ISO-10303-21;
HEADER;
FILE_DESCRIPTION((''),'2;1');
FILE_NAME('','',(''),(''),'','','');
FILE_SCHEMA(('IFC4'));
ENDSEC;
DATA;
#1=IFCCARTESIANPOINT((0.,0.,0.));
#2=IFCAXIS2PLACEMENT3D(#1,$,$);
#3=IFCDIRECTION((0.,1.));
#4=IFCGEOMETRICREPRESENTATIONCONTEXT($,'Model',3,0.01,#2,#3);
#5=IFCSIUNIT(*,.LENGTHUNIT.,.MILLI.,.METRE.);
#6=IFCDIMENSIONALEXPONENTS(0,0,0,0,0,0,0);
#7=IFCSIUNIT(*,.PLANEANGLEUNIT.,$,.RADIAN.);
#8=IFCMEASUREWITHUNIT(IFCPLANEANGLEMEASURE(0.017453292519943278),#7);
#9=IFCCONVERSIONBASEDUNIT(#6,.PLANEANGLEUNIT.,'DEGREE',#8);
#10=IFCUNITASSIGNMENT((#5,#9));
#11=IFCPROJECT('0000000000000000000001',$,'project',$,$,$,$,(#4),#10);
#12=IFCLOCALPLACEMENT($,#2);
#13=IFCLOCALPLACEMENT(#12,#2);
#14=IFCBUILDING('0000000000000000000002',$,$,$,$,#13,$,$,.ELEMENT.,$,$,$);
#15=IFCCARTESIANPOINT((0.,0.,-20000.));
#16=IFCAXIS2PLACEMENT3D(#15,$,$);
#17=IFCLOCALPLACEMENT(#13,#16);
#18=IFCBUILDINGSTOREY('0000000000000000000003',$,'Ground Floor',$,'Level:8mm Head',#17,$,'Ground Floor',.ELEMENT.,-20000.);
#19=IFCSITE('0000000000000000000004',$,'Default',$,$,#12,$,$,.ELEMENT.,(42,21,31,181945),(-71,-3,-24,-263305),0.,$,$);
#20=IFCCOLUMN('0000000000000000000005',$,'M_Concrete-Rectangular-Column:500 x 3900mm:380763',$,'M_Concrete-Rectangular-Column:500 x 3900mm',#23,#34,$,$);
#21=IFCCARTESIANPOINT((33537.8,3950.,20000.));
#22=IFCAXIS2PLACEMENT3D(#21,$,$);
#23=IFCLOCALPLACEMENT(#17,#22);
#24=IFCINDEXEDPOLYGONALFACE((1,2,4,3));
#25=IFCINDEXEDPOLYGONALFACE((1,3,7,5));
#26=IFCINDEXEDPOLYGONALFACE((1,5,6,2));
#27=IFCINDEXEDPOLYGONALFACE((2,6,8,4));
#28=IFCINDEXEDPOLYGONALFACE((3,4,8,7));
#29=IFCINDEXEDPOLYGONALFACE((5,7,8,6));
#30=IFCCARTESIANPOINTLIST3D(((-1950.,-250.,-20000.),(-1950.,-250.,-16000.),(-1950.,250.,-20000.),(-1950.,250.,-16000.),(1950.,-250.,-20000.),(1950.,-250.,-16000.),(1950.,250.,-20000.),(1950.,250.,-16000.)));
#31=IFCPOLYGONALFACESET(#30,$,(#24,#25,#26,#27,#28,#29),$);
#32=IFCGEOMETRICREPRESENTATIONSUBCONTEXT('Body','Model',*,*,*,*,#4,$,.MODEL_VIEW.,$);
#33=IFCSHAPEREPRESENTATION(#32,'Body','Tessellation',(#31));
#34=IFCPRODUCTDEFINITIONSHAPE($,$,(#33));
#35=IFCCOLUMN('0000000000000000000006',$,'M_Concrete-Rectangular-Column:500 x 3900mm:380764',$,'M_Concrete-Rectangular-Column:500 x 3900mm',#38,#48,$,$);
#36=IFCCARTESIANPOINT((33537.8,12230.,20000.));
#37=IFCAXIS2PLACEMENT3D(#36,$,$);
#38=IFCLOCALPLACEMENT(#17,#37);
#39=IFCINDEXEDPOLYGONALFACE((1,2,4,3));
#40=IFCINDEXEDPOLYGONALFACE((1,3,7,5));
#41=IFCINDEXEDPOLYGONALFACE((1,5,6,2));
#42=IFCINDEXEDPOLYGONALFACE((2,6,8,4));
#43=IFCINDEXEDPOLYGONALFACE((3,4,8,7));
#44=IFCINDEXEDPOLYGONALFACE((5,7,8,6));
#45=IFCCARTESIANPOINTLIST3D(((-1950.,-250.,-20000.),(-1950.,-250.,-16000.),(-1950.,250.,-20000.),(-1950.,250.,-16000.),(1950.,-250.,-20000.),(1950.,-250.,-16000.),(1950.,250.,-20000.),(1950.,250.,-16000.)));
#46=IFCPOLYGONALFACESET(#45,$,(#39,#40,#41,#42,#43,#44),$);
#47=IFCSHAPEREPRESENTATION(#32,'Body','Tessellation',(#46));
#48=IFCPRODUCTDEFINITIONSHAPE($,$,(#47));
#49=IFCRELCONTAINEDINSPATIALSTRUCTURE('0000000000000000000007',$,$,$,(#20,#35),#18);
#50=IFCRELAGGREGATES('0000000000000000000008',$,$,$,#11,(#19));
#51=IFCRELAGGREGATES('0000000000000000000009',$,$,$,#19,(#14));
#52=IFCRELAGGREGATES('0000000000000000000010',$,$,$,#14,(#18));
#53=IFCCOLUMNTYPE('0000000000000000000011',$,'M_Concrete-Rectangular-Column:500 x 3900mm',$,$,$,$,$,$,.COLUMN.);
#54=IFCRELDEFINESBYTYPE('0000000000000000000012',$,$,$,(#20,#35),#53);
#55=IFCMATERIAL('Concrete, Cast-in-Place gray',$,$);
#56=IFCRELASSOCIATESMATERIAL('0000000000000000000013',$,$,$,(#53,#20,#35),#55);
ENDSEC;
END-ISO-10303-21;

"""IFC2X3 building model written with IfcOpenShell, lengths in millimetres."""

from ifc_helpers import new_model, entity, si_unit, converted_unit, direction, frame, origin, origin_2d_with_axis, place, context, subcontext, project, spatial, rectangle, extrude, source, transform, mapped, material, type_object, type_shapes, element, save


model = new_model("IFC2X3")

# Units and contexts
model_context = context("Model", 3, precision=0.01, world=origin(), true_north=direction((0.0, 1.0)))
body_context = subcontext(model_context, "Body", "Model", "MODEL_VIEW")
ifc_project = project(units=[si_unit("LENGTHUNIT", "METRE", prefix="MILLI"), converted_unit("PLANEANGLEUNIT", "DEGREE", entity("IfcPlaneAngleMeasure", 0.017453292519943278), si_unit("PLANEANGLEUNIT", "RADIAN"), dimensions=[0, 0, 0, 0, 0, 0, 0])], contexts=[model_context])

# Site, building, storey
site_placement = place(None, origin())
site = spatial("IfcSite", under=ifc_project, at=site_placement, Name="Default", CompositionType="ELEMENT", RefLatitude=(42, 21, 31, 181945), RefLongitude=(-71, -3, -24, -263305), RefElevation=0.0)
building_placement = place(site_placement, origin())
building = spatial("IfcBuilding", under=site, at=building_placement, CompositionType="ELEMENT")
storey_placement = place(building_placement, frame((0.0, 0.0, -20000.0)))
storey = spatial("IfcBuildingStorey", under=building, at=storey_placement, Name="Ground Floor", ObjectType="Level:8mm Head", LongName="Ground Floor", CompositionType="ELEMENT", Elevation=-20000.0)

# Columns
ifc_material_1 = material(Name="Concrete, Cast-in-Place gray")
column_type = type_object("IfcColumnType", Name="M_Concrete-Rectangular-Column:500 x 3900mm", PredefinedType="COLUMN", material=ifc_material_1)
shared_shape = source(origin(), body_context, "Body", "SweptSolid", [
    extrude(rectangle(XDim=3900.0, YDim=500.0, at=origin_2d_with_axis()), frame((0.0, 0.0, -20000.0), z_axis=(0.0, 0.0, 1.0), x_axis=(-1.0, 0.0, 0.0)), (0.0, 0.0, 1.0), 4000.0),
])
type_shapes(column_type, [shared_shape])
for number, where, name in (
    (1, (33537.8, 3950.0, 20000.0), "M_Concrete-Rectangular-Column:500 x 3900mm:380763"),
    (2, (33537.8, 12230.0, 20000.0), "M_Concrete-Rectangular-Column:500 x 3900mm:380764"),
):
    element("IfcColumn", number, at=place(storey_placement, frame(where)), inside=storey, type_object=column_type, material=ifc_material_1, Name=name, ObjectType="M_Concrete-Rectangular-Column:500 x 3900mm", context=body_context, shape_type="MappedRepresentation", body=[
        mapped(shared_shape, transform((0.0, 0.0, 0.0), scale=1.0)),
    ])

save(model, "model.ifc")
